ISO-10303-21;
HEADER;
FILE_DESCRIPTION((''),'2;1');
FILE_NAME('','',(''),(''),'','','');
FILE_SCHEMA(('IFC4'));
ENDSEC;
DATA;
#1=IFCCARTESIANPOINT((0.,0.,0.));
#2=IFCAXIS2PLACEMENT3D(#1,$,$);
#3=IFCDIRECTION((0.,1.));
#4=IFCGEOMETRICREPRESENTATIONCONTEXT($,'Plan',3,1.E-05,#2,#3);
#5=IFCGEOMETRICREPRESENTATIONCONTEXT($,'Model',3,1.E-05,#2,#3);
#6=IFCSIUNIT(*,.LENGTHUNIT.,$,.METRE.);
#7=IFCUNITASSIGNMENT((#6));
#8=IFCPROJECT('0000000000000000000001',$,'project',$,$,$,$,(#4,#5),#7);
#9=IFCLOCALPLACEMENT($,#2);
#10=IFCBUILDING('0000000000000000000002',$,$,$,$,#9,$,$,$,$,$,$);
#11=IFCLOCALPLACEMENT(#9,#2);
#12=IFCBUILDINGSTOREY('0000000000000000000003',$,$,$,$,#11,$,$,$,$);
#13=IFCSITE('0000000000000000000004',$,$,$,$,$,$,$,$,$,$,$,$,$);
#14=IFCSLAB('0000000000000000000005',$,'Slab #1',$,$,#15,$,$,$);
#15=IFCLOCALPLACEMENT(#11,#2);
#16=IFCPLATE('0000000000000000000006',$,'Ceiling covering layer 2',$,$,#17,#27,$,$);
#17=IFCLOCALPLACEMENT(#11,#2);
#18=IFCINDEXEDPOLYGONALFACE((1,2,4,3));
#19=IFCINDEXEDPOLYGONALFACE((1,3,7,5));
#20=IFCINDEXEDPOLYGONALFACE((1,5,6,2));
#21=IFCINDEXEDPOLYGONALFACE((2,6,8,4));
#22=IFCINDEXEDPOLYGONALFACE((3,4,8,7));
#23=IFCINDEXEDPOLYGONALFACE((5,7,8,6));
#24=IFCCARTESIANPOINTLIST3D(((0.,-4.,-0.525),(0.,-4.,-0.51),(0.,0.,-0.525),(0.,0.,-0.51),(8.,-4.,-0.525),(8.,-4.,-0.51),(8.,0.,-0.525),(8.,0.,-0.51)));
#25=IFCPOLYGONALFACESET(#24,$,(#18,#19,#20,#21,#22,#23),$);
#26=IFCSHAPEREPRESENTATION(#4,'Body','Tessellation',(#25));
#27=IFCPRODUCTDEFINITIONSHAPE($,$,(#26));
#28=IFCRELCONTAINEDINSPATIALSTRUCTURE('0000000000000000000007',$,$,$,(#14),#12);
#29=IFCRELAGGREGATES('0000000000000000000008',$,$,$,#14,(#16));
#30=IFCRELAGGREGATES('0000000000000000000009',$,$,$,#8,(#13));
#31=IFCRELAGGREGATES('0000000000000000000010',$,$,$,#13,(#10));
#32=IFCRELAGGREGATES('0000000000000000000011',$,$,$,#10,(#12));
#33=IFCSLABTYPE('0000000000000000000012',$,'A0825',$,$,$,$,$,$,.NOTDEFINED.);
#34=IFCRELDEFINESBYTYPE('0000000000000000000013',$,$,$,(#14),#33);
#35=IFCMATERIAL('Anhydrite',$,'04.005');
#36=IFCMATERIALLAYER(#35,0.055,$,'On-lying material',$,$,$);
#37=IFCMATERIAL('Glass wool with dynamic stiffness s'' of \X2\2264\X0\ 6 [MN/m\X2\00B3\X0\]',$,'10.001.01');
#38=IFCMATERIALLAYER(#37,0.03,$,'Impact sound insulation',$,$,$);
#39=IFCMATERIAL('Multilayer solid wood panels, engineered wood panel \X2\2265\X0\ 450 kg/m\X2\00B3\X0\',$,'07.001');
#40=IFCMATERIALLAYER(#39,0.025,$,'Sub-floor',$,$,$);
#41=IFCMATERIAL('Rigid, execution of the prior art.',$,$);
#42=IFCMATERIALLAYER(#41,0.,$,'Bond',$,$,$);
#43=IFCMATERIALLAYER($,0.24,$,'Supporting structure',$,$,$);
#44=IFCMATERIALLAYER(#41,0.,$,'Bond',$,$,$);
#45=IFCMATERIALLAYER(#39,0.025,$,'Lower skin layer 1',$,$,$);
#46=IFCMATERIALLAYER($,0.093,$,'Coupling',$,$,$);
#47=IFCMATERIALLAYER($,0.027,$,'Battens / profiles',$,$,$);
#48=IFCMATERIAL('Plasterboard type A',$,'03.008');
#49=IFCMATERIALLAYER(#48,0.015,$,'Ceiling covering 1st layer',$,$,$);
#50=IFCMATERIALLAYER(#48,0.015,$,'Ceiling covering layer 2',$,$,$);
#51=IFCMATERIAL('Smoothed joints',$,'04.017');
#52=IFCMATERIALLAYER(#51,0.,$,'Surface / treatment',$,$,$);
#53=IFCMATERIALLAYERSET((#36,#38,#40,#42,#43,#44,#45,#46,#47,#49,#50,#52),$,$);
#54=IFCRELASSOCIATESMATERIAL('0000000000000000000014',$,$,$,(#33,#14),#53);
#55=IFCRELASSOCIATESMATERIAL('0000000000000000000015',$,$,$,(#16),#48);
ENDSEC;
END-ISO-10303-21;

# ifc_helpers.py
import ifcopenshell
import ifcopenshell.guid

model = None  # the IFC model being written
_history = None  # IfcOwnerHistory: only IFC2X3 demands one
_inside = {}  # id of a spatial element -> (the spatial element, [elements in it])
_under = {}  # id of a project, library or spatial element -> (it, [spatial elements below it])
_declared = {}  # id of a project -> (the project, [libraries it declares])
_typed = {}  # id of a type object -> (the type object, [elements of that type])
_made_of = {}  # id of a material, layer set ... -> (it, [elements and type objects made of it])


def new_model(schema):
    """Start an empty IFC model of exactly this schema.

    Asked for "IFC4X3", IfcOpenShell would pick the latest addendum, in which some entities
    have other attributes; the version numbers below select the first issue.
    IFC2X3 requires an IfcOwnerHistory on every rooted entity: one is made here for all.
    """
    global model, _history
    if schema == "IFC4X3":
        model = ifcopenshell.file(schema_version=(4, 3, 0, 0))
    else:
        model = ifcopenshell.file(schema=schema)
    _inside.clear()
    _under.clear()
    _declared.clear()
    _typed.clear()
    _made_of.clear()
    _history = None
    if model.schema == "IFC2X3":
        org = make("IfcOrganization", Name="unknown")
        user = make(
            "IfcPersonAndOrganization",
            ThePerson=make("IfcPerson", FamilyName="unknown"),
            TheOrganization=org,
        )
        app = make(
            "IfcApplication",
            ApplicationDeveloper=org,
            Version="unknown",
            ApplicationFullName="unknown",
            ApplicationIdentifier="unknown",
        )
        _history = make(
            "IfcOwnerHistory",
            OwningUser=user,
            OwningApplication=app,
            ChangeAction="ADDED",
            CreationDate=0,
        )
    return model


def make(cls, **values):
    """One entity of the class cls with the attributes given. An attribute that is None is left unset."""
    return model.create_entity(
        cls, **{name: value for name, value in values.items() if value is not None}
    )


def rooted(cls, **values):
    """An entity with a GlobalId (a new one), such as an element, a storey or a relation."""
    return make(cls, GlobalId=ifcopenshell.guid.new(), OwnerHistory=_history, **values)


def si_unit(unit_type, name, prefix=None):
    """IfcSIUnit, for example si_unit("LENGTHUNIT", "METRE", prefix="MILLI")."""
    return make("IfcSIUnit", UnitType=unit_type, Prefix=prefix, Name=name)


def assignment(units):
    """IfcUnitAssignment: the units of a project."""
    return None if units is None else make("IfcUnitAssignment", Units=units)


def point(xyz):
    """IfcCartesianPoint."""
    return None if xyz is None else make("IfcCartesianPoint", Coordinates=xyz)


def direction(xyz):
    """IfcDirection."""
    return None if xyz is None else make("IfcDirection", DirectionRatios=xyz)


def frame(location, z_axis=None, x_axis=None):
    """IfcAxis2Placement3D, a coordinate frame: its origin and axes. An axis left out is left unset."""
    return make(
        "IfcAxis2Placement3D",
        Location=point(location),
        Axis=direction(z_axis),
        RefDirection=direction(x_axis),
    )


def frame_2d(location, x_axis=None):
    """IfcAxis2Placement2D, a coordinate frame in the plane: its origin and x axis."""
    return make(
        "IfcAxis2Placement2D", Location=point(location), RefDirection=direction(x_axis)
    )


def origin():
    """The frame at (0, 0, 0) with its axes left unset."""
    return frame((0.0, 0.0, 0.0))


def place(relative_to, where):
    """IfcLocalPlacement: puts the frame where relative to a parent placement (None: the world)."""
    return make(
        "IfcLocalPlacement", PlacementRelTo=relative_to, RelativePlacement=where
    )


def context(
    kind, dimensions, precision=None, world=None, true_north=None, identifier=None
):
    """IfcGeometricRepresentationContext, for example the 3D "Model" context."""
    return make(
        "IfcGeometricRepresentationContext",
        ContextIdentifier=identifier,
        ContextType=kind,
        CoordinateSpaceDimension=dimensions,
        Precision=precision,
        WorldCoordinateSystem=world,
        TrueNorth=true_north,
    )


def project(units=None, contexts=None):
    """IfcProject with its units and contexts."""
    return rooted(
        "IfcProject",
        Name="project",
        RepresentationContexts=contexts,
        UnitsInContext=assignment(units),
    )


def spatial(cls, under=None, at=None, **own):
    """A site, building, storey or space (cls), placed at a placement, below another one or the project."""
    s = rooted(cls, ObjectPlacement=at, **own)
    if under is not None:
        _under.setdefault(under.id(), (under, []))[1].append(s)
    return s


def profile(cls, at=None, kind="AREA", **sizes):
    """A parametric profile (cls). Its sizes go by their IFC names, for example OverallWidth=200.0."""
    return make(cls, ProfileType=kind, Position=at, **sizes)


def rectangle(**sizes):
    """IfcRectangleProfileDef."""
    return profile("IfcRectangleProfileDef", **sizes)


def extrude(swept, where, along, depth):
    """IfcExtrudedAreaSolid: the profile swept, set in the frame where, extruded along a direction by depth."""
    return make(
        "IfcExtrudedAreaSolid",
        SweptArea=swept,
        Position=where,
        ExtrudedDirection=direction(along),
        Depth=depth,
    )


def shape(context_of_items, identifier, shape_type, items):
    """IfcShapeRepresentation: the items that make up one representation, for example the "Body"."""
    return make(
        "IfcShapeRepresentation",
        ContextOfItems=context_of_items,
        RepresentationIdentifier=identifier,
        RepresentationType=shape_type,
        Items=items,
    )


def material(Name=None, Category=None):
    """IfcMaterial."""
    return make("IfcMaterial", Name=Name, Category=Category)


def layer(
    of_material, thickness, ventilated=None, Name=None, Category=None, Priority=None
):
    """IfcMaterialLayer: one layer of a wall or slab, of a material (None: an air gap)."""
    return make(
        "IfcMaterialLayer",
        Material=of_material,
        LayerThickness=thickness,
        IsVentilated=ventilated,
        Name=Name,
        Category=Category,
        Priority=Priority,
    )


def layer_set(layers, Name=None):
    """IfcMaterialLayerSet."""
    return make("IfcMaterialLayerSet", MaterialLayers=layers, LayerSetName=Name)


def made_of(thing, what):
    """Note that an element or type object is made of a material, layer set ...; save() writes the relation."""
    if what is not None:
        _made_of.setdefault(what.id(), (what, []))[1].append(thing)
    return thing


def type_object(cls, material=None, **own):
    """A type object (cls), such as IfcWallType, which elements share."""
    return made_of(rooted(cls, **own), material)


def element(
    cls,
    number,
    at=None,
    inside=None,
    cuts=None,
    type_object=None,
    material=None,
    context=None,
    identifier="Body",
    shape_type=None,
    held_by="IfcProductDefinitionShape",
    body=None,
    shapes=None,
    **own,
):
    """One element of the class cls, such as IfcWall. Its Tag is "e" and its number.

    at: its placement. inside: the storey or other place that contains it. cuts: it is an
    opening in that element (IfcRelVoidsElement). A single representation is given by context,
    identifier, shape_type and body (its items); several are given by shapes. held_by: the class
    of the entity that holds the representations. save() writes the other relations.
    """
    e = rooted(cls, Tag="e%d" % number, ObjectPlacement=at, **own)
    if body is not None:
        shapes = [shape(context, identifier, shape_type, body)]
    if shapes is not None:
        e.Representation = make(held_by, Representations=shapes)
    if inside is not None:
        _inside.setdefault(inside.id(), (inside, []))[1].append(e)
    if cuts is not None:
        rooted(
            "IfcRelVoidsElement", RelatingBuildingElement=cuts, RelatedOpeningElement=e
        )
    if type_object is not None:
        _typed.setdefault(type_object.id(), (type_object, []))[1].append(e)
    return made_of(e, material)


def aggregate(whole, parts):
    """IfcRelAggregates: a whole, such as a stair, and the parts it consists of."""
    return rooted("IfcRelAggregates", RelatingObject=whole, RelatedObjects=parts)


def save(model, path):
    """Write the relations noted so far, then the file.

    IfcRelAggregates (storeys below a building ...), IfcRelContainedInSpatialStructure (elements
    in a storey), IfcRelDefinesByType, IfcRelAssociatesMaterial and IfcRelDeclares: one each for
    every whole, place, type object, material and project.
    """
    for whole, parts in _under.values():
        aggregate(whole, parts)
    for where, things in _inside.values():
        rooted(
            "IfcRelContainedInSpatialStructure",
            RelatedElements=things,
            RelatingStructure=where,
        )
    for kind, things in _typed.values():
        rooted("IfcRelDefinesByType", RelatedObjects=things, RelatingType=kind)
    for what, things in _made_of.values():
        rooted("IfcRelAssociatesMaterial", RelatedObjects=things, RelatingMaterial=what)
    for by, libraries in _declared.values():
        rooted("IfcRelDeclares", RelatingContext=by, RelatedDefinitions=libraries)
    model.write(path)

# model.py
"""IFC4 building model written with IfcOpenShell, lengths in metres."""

from ifc_helpers import new_model, si_unit, direction, frame, frame_2d, origin, place, context, project, spatial, rectangle, extrude, material, layer, layer_set, type_object, element, aggregate, save


model = new_model("IFC4")

# Units and contexts
plan_context = context("Plan", 3, precision=1e-05, world=origin(), true_north=direction((0.0, 1.0)))
model_context = context("Model", 3, precision=1e-05, world=origin(), true_north=direction((0.0, 1.0)))
ifc_project = project(units=[si_unit("LENGTHUNIT", "METRE")], contexts=[plan_context, model_context])

# Site, building, storey
site = spatial("IfcSite", under=ifc_project)
building_placement = place(None, origin())
building = spatial("IfcBuilding", under=site, at=building_placement)
storey_placement = place(building_placement, origin())
storey = spatial("IfcBuildingStorey", under=building, at=storey_placement)

# Slab, plate
ifc_material_1 = material(Name="Anhydrite", Category="04.005")
ifc_layer_1 = layer(ifc_material_1, 0.055, Name="On-lying material")
ifc_material_2 = material(Name="Glass wool with dynamic stiffness s' of ≤ 6 [MN/m³]", Category="10.001.01")
ifc_layer_2 = layer(ifc_material_2, 0.03, Name="Impact sound insulation")
ifc_material_3 = material(Name="Multilayer solid wood panels, engineered wood panel ≥ 450 kg/m³", Category="07.001")
ifc_layer_3 = layer(ifc_material_3, 0.025, Name="Sub-floor")
ifc_material_4 = material(Name="Rigid, execution of the prior art.")
ifc_layer_4 = layer(ifc_material_4, 0.0, Name="Bond")
ifc_layer_5 = layer(None, 0.24, Name="Supporting structure")
ifc_layer_6 = layer(ifc_material_4, 0.0, Name="Bond")
ifc_layer_7 = layer(ifc_material_3, 0.025, Name="Lower skin layer 1")
ifc_layer_8 = layer(None, 0.093, Name="Coupling")
ifc_layer_9 = layer(None, 0.027, Name="Battens / profiles")
ifc_material_5 = material(Name="Plasterboard type A", Category="03.008")
ifc_layer_10 = layer(ifc_material_5, 0.015, Name="Ceiling covering 1st layer")
ifc_layer_11 = layer(ifc_material_5, 0.015, Name="Ceiling covering layer 2")
ifc_material_6 = material(Name="Smoothed joints", Category="04.017")
ifc_layer_12 = layer(ifc_material_6, 0.0, Name="Surface / treatment")
ifc_layer_set = layer_set([ifc_layer_1, ifc_layer_2, ifc_layer_3, ifc_layer_4, ifc_layer_5, ifc_layer_6, ifc_layer_7, ifc_layer_8, ifc_layer_9, ifc_layer_10, ifc_layer_11, ifc_layer_12])
slab_type = type_object("IfcSlabType", Name="A0825", PredefinedType="NOTDEFINED", material=ifc_layer_set)
slab_placement = place(None, frame((0.0, 0.0, 0.0), z_axis=(0.0, 0.0, -1.0), x_axis=(1.0, 0.0, 0.0)))
slab = element("IfcSlab", 1, at=slab_placement, inside=storey, type_object=slab_type, material=ifc_layer_set, Name="Slab #1")
plate_1_placement = place(slab_placement, origin())
plate_1 = element("IfcPlate", 2, at=plate_1_placement, material=ifc_material_5, Name="Ceiling covering layer 2", context=plan_context, shape_type="SweptSolid", body=[
    extrude(rectangle(XDim=8.0, YDim=4.0, at=frame_2d((4.0, 2.0), x_axis=(1.0, 0.0))), frame((0.0, 0.0, 0.51), z_axis=(0.0, 0.0, 1.0), x_axis=(1.0, 0.0, 0.0)), (0.0, 0.0, 1.0), 0.015),
])
aggregate(slab, [plate_1])

save(model, "model.ifc")
